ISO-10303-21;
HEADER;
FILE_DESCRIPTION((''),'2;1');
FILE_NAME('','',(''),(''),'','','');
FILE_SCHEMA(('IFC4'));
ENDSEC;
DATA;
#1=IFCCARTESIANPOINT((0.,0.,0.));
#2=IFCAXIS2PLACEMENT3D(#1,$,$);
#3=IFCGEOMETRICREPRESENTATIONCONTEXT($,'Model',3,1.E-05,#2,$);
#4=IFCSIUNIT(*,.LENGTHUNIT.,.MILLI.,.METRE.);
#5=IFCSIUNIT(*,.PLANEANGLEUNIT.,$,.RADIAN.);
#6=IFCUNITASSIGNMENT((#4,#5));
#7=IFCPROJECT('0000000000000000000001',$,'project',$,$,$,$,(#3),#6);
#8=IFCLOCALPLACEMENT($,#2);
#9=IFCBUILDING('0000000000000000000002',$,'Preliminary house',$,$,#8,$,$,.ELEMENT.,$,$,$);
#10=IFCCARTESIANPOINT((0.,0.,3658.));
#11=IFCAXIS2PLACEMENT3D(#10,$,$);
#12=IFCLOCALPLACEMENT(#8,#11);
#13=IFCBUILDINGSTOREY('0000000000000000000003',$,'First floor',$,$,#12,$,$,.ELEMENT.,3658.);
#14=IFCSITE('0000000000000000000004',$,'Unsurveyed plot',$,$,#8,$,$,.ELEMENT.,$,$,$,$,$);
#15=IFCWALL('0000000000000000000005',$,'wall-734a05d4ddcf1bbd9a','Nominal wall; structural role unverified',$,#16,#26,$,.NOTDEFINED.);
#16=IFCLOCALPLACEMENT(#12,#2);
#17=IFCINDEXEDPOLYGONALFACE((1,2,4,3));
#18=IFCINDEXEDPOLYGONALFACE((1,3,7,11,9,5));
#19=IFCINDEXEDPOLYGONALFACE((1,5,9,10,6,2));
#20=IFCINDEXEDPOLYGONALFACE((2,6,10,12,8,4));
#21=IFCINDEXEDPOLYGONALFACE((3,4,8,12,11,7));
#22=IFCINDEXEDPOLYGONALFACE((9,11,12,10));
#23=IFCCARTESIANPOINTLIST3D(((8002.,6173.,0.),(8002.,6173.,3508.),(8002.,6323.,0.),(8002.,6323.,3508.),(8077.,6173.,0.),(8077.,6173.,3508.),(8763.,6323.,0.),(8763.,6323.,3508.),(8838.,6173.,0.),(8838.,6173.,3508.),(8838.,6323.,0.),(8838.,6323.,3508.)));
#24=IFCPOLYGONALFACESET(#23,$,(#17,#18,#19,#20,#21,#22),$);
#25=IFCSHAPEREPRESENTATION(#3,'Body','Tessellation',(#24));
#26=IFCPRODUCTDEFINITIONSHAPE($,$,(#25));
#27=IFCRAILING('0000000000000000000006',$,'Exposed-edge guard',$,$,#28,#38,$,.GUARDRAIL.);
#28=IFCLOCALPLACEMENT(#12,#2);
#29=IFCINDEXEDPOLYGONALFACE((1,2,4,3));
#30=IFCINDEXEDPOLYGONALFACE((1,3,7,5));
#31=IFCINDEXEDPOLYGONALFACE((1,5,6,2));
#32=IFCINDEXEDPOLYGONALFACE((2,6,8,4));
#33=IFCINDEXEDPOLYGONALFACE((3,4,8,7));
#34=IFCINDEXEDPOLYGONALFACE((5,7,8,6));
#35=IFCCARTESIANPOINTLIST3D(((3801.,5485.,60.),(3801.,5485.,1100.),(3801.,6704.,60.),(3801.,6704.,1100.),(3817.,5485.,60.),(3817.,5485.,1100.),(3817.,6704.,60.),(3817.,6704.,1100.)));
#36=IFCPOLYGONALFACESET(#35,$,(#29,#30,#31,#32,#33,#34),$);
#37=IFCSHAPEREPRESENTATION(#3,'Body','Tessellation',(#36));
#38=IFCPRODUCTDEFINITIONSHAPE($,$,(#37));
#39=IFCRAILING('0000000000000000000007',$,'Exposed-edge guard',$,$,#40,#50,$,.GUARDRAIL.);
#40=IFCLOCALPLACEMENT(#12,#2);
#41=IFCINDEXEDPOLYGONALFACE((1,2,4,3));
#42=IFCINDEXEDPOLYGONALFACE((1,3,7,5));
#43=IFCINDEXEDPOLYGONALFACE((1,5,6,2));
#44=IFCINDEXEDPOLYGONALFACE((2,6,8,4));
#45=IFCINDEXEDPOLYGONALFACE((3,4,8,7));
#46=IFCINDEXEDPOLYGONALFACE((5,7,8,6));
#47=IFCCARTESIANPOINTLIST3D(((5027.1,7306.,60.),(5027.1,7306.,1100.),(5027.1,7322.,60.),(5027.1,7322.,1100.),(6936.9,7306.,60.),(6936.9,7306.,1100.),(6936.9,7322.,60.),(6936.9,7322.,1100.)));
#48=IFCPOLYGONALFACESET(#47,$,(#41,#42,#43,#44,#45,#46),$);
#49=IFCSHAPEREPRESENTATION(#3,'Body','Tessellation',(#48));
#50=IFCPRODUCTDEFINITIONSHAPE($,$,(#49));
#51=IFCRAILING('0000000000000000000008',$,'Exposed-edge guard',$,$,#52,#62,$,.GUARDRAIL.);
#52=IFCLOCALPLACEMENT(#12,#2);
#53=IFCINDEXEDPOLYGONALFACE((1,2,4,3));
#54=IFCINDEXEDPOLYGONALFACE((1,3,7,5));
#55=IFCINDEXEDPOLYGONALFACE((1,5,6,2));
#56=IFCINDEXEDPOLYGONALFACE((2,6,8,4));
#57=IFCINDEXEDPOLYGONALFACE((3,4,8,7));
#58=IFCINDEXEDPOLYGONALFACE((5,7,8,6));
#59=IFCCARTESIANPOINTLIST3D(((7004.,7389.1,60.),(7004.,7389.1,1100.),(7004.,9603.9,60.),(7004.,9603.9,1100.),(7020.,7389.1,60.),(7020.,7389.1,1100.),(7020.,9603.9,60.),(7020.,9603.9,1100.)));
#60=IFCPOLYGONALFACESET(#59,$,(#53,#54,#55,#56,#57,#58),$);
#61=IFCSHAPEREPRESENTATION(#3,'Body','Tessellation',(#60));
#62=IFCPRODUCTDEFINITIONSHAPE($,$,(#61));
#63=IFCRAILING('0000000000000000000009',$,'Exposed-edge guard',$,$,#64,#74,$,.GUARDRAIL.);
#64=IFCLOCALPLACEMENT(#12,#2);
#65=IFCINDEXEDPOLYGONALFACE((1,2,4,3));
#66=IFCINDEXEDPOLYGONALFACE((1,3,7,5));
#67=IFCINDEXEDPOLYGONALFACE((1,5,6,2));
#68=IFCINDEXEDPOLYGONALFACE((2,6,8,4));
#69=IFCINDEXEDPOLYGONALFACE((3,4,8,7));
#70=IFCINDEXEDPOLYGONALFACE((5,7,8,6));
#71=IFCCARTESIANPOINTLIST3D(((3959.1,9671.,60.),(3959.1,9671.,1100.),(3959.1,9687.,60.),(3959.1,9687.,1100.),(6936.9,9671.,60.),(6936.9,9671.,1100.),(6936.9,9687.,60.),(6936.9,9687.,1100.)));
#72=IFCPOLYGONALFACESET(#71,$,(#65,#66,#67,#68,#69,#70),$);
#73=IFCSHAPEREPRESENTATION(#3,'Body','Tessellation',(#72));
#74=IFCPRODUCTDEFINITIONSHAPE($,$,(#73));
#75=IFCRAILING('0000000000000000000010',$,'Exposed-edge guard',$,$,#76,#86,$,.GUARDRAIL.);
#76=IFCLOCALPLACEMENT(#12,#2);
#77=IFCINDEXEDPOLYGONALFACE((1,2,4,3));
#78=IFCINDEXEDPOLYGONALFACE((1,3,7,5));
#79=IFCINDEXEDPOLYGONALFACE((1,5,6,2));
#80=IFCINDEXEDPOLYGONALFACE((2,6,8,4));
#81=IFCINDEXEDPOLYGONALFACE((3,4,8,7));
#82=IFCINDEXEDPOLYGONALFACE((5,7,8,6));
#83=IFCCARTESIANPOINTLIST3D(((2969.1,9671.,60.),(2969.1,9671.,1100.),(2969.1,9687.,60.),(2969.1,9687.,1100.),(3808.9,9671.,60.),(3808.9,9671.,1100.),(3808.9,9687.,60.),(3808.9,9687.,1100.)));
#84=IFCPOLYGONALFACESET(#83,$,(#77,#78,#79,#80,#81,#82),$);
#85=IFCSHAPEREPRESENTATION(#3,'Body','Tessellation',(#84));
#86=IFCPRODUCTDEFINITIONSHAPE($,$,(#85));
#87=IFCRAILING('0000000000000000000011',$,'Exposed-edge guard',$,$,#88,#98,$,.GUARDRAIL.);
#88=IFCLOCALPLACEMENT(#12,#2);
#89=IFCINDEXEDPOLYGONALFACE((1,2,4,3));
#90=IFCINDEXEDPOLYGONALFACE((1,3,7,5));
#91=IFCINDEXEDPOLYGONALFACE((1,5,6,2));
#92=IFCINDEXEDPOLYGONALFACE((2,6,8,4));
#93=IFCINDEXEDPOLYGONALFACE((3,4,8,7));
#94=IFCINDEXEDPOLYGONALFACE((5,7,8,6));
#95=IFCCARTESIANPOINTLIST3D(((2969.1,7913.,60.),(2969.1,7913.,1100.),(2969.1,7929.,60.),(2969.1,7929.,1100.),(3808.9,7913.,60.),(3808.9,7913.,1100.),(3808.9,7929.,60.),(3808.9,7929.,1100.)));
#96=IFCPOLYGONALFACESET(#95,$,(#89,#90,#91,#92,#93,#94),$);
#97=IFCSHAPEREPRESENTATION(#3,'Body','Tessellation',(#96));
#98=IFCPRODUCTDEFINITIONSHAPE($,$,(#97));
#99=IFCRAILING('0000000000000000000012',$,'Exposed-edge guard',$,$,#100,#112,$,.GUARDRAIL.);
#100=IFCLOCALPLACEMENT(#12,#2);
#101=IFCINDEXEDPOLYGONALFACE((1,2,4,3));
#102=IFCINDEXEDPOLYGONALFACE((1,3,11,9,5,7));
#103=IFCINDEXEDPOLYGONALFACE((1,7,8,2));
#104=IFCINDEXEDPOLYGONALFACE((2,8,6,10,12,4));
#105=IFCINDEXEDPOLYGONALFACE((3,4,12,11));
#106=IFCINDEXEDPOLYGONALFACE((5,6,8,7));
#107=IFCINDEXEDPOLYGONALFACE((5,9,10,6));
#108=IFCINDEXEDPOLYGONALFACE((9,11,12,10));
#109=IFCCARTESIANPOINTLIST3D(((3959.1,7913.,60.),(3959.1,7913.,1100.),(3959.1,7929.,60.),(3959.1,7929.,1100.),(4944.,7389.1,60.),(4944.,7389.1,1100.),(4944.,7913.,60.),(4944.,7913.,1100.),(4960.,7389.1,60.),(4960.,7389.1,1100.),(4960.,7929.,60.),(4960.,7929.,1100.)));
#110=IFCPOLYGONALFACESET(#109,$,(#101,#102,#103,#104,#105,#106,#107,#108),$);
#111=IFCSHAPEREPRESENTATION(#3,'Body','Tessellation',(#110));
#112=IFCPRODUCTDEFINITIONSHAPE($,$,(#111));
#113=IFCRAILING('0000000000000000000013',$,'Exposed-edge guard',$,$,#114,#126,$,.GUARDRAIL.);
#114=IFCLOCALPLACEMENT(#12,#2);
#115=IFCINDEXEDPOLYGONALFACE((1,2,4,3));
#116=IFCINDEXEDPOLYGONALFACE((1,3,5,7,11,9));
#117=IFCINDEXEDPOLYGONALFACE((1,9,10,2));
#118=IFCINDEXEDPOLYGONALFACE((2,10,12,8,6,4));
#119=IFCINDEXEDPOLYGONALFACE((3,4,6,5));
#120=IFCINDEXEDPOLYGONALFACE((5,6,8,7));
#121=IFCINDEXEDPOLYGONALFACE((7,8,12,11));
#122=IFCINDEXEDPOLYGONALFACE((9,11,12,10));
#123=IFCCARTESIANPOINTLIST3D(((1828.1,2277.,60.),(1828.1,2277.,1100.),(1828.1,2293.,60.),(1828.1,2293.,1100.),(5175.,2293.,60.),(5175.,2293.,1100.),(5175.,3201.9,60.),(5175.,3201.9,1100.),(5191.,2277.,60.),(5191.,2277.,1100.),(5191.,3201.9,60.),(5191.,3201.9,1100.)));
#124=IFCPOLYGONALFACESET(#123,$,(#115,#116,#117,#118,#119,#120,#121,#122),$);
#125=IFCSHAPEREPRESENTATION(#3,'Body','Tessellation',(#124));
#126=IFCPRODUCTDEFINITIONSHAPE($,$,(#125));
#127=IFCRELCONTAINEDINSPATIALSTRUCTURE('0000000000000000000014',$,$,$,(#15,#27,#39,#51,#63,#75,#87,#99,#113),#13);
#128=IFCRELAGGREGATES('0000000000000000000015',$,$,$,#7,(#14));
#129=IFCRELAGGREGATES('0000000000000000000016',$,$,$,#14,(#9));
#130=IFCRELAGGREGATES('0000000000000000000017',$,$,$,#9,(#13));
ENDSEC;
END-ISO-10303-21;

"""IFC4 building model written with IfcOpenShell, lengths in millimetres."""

from ifc_helpers import new_model, si_unit, frame, origin, place, context, project, spatial, polyline, outline, extrude, element, save


model = new_model("IFC4")

# Units and contexts
model_context = context("Model", 3, precision=1e-05, world=origin())
ifc_project = project(units=[si_unit("LENGTHUNIT", "METRE", prefix="MILLI"), si_unit("PLANEANGLEUNIT", "RADIAN")], contexts=[model_context])

# Site, building, storey
placement_1 = place(None, origin())
site = spatial("IfcSite", under=ifc_project, at=placement_1, Name="Unsurveyed plot", CompositionType="ELEMENT")
building = spatial("IfcBuilding", under=site, at=placement_1, Name="Preliminary house", CompositionType="ELEMENT")
placement_2 = place(placement_1, frame((0.0, 0.0, 3658.0)))
storey = spatial("IfcBuildingStorey", under=building, at=placement_2, Name="First floor", CompositionType="ELEMENT", Elevation=3658.0)

# Wall
element("IfcWall", 1, at=placement_2, inside=storey, Name="wall-734a05d4ddcf1bbd9a", Description="Nominal wall; structural role unverified", PredefinedType="NOTDEFINED", context=model_context, shape_type="SweptSolid", body=[
    extrude(outline(polyline([(8763.0, 6323.0), (8838.0, 6323.0), (8838.0, 6173.0), (8077.0, 6173.0), (8002.0, 6173.0), (8002.0, 6323.0), (8763.0, 6323.0)])), origin(), (0.0, 0.0, 1.0), 3508.0),
])

# Railings
element("IfcRailing", 2, at=placement_2, inside=storey, Name="Exposed-edge guard", PredefinedType="GUARDRAIL", context=model_context, shape_type="SweptSolid", body=[
    extrude(outline(polyline([(3801.0, 6704.0), (3817.0, 6704.0), (3817.0, 5485.0), (3801.0, 5485.0), (3801.0, 6704.0)])), frame((0.0, 0.0, 60.0)), (0.0, 0.0, 1.0), 1040.0),
])
element("IfcRailing", 3, at=placement_2, inside=storey, Name="Exposed-edge guard", PredefinedType="GUARDRAIL", context=model_context, shape_type="SweptSolid", body=[
    extrude(outline(polyline([(6936.9, 7322.0), (6936.9, 7306.0), (5027.1, 7306.0), (5027.1, 7322.0), (6936.9, 7322.0)])), frame((0.0, 0.0, 60.0)), (0.0, 0.0, 1.0), 1040.0),
])
element("IfcRailing", 4, at=placement_2, inside=storey, Name="Exposed-edge guard", PredefinedType="GUARDRAIL", context=model_context, shape_type="SweptSolid", body=[
    extrude(outline(polyline([(7004.0, 9603.9), (7020.0, 9603.9), (7020.0, 7389.1), (7004.0, 7389.1), (7004.0, 9603.9)])), frame((0.0, 0.0, 60.0)), (0.0, 0.0, 1.0), 1040.0),
])
element("IfcRailing", 5, at=placement_2, inside=storey, Name="Exposed-edge guard", PredefinedType="GUARDRAIL", context=model_context, shape_type="SweptSolid", body=[
    extrude(outline(polyline([(3959.1, 9671.0), (3959.1, 9687.0), (6936.9, 9687.0), (6936.9, 9671.0), (3959.1, 9671.0)])), frame((0.0, 0.0, 60.0)), (0.0, 0.0, 1.0), 1040.0),
])
element("IfcRailing", 6, at=placement_2, inside=storey, Name="Exposed-edge guard", PredefinedType="GUARDRAIL", context=model_context, shape_type="SweptSolid", body=[
    extrude(outline(polyline([(2969.1, 9671.0), (2969.1, 9687.0), (3808.9, 9687.0), (3808.9, 9671.0), (2969.1, 9671.0)])), frame((0.0, 0.0, 60.0)), (0.0, 0.0, 1.0), 1040.0),
])
element("IfcRailing", 7, at=placement_2, inside=storey, Name="Exposed-edge guard", PredefinedType="GUARDRAIL", context=model_context, shape_type="SweptSolid", body=[
    extrude(outline(polyline([(3808.9, 7929.0), (3808.9, 7913.0), (2969.1, 7913.0), (2969.1, 7929.0), (3808.9, 7929.0)])), frame((0.0, 0.0, 60.0)), (0.0, 0.0, 1.0), 1040.0),
])
element("IfcRailing", 8, at=placement_2, inside=storey, Name="Exposed-edge guard", PredefinedType="GUARDRAIL", context=model_context, shape_type="SweptSolid", body=[
    extrude(outline(polyline([(4960.0, 7929.0), (4960.0, 7389.1), (4944.0, 7389.1), (4944.0, 7913.0), (3959.1, 7913.0), (3959.1, 7929.0), (4960.0, 7929.0)])), frame((0.0, 0.0, 60.0)), (0.0, 0.0, 1.0), 1040.0),
])
element("IfcRailing", 9, at=placement_2, inside=storey, Name="Exposed-edge guard", PredefinedType="GUARDRAIL", context=model_context, shape_type="SweptSolid", body=[
    extrude(outline(polyline([(5175.0, 2293.0), (5175.0, 3201.9), (5191.0, 3201.9), (5191.0, 2277.0), (1828.1, 2277.0), (1828.1, 2293.0), (5175.0, 2293.0)])), frame((0.0, 0.0, 60.0)), (0.0, 0.0, 1.0), 1040.0),
])

save(model, "model.ifc")
